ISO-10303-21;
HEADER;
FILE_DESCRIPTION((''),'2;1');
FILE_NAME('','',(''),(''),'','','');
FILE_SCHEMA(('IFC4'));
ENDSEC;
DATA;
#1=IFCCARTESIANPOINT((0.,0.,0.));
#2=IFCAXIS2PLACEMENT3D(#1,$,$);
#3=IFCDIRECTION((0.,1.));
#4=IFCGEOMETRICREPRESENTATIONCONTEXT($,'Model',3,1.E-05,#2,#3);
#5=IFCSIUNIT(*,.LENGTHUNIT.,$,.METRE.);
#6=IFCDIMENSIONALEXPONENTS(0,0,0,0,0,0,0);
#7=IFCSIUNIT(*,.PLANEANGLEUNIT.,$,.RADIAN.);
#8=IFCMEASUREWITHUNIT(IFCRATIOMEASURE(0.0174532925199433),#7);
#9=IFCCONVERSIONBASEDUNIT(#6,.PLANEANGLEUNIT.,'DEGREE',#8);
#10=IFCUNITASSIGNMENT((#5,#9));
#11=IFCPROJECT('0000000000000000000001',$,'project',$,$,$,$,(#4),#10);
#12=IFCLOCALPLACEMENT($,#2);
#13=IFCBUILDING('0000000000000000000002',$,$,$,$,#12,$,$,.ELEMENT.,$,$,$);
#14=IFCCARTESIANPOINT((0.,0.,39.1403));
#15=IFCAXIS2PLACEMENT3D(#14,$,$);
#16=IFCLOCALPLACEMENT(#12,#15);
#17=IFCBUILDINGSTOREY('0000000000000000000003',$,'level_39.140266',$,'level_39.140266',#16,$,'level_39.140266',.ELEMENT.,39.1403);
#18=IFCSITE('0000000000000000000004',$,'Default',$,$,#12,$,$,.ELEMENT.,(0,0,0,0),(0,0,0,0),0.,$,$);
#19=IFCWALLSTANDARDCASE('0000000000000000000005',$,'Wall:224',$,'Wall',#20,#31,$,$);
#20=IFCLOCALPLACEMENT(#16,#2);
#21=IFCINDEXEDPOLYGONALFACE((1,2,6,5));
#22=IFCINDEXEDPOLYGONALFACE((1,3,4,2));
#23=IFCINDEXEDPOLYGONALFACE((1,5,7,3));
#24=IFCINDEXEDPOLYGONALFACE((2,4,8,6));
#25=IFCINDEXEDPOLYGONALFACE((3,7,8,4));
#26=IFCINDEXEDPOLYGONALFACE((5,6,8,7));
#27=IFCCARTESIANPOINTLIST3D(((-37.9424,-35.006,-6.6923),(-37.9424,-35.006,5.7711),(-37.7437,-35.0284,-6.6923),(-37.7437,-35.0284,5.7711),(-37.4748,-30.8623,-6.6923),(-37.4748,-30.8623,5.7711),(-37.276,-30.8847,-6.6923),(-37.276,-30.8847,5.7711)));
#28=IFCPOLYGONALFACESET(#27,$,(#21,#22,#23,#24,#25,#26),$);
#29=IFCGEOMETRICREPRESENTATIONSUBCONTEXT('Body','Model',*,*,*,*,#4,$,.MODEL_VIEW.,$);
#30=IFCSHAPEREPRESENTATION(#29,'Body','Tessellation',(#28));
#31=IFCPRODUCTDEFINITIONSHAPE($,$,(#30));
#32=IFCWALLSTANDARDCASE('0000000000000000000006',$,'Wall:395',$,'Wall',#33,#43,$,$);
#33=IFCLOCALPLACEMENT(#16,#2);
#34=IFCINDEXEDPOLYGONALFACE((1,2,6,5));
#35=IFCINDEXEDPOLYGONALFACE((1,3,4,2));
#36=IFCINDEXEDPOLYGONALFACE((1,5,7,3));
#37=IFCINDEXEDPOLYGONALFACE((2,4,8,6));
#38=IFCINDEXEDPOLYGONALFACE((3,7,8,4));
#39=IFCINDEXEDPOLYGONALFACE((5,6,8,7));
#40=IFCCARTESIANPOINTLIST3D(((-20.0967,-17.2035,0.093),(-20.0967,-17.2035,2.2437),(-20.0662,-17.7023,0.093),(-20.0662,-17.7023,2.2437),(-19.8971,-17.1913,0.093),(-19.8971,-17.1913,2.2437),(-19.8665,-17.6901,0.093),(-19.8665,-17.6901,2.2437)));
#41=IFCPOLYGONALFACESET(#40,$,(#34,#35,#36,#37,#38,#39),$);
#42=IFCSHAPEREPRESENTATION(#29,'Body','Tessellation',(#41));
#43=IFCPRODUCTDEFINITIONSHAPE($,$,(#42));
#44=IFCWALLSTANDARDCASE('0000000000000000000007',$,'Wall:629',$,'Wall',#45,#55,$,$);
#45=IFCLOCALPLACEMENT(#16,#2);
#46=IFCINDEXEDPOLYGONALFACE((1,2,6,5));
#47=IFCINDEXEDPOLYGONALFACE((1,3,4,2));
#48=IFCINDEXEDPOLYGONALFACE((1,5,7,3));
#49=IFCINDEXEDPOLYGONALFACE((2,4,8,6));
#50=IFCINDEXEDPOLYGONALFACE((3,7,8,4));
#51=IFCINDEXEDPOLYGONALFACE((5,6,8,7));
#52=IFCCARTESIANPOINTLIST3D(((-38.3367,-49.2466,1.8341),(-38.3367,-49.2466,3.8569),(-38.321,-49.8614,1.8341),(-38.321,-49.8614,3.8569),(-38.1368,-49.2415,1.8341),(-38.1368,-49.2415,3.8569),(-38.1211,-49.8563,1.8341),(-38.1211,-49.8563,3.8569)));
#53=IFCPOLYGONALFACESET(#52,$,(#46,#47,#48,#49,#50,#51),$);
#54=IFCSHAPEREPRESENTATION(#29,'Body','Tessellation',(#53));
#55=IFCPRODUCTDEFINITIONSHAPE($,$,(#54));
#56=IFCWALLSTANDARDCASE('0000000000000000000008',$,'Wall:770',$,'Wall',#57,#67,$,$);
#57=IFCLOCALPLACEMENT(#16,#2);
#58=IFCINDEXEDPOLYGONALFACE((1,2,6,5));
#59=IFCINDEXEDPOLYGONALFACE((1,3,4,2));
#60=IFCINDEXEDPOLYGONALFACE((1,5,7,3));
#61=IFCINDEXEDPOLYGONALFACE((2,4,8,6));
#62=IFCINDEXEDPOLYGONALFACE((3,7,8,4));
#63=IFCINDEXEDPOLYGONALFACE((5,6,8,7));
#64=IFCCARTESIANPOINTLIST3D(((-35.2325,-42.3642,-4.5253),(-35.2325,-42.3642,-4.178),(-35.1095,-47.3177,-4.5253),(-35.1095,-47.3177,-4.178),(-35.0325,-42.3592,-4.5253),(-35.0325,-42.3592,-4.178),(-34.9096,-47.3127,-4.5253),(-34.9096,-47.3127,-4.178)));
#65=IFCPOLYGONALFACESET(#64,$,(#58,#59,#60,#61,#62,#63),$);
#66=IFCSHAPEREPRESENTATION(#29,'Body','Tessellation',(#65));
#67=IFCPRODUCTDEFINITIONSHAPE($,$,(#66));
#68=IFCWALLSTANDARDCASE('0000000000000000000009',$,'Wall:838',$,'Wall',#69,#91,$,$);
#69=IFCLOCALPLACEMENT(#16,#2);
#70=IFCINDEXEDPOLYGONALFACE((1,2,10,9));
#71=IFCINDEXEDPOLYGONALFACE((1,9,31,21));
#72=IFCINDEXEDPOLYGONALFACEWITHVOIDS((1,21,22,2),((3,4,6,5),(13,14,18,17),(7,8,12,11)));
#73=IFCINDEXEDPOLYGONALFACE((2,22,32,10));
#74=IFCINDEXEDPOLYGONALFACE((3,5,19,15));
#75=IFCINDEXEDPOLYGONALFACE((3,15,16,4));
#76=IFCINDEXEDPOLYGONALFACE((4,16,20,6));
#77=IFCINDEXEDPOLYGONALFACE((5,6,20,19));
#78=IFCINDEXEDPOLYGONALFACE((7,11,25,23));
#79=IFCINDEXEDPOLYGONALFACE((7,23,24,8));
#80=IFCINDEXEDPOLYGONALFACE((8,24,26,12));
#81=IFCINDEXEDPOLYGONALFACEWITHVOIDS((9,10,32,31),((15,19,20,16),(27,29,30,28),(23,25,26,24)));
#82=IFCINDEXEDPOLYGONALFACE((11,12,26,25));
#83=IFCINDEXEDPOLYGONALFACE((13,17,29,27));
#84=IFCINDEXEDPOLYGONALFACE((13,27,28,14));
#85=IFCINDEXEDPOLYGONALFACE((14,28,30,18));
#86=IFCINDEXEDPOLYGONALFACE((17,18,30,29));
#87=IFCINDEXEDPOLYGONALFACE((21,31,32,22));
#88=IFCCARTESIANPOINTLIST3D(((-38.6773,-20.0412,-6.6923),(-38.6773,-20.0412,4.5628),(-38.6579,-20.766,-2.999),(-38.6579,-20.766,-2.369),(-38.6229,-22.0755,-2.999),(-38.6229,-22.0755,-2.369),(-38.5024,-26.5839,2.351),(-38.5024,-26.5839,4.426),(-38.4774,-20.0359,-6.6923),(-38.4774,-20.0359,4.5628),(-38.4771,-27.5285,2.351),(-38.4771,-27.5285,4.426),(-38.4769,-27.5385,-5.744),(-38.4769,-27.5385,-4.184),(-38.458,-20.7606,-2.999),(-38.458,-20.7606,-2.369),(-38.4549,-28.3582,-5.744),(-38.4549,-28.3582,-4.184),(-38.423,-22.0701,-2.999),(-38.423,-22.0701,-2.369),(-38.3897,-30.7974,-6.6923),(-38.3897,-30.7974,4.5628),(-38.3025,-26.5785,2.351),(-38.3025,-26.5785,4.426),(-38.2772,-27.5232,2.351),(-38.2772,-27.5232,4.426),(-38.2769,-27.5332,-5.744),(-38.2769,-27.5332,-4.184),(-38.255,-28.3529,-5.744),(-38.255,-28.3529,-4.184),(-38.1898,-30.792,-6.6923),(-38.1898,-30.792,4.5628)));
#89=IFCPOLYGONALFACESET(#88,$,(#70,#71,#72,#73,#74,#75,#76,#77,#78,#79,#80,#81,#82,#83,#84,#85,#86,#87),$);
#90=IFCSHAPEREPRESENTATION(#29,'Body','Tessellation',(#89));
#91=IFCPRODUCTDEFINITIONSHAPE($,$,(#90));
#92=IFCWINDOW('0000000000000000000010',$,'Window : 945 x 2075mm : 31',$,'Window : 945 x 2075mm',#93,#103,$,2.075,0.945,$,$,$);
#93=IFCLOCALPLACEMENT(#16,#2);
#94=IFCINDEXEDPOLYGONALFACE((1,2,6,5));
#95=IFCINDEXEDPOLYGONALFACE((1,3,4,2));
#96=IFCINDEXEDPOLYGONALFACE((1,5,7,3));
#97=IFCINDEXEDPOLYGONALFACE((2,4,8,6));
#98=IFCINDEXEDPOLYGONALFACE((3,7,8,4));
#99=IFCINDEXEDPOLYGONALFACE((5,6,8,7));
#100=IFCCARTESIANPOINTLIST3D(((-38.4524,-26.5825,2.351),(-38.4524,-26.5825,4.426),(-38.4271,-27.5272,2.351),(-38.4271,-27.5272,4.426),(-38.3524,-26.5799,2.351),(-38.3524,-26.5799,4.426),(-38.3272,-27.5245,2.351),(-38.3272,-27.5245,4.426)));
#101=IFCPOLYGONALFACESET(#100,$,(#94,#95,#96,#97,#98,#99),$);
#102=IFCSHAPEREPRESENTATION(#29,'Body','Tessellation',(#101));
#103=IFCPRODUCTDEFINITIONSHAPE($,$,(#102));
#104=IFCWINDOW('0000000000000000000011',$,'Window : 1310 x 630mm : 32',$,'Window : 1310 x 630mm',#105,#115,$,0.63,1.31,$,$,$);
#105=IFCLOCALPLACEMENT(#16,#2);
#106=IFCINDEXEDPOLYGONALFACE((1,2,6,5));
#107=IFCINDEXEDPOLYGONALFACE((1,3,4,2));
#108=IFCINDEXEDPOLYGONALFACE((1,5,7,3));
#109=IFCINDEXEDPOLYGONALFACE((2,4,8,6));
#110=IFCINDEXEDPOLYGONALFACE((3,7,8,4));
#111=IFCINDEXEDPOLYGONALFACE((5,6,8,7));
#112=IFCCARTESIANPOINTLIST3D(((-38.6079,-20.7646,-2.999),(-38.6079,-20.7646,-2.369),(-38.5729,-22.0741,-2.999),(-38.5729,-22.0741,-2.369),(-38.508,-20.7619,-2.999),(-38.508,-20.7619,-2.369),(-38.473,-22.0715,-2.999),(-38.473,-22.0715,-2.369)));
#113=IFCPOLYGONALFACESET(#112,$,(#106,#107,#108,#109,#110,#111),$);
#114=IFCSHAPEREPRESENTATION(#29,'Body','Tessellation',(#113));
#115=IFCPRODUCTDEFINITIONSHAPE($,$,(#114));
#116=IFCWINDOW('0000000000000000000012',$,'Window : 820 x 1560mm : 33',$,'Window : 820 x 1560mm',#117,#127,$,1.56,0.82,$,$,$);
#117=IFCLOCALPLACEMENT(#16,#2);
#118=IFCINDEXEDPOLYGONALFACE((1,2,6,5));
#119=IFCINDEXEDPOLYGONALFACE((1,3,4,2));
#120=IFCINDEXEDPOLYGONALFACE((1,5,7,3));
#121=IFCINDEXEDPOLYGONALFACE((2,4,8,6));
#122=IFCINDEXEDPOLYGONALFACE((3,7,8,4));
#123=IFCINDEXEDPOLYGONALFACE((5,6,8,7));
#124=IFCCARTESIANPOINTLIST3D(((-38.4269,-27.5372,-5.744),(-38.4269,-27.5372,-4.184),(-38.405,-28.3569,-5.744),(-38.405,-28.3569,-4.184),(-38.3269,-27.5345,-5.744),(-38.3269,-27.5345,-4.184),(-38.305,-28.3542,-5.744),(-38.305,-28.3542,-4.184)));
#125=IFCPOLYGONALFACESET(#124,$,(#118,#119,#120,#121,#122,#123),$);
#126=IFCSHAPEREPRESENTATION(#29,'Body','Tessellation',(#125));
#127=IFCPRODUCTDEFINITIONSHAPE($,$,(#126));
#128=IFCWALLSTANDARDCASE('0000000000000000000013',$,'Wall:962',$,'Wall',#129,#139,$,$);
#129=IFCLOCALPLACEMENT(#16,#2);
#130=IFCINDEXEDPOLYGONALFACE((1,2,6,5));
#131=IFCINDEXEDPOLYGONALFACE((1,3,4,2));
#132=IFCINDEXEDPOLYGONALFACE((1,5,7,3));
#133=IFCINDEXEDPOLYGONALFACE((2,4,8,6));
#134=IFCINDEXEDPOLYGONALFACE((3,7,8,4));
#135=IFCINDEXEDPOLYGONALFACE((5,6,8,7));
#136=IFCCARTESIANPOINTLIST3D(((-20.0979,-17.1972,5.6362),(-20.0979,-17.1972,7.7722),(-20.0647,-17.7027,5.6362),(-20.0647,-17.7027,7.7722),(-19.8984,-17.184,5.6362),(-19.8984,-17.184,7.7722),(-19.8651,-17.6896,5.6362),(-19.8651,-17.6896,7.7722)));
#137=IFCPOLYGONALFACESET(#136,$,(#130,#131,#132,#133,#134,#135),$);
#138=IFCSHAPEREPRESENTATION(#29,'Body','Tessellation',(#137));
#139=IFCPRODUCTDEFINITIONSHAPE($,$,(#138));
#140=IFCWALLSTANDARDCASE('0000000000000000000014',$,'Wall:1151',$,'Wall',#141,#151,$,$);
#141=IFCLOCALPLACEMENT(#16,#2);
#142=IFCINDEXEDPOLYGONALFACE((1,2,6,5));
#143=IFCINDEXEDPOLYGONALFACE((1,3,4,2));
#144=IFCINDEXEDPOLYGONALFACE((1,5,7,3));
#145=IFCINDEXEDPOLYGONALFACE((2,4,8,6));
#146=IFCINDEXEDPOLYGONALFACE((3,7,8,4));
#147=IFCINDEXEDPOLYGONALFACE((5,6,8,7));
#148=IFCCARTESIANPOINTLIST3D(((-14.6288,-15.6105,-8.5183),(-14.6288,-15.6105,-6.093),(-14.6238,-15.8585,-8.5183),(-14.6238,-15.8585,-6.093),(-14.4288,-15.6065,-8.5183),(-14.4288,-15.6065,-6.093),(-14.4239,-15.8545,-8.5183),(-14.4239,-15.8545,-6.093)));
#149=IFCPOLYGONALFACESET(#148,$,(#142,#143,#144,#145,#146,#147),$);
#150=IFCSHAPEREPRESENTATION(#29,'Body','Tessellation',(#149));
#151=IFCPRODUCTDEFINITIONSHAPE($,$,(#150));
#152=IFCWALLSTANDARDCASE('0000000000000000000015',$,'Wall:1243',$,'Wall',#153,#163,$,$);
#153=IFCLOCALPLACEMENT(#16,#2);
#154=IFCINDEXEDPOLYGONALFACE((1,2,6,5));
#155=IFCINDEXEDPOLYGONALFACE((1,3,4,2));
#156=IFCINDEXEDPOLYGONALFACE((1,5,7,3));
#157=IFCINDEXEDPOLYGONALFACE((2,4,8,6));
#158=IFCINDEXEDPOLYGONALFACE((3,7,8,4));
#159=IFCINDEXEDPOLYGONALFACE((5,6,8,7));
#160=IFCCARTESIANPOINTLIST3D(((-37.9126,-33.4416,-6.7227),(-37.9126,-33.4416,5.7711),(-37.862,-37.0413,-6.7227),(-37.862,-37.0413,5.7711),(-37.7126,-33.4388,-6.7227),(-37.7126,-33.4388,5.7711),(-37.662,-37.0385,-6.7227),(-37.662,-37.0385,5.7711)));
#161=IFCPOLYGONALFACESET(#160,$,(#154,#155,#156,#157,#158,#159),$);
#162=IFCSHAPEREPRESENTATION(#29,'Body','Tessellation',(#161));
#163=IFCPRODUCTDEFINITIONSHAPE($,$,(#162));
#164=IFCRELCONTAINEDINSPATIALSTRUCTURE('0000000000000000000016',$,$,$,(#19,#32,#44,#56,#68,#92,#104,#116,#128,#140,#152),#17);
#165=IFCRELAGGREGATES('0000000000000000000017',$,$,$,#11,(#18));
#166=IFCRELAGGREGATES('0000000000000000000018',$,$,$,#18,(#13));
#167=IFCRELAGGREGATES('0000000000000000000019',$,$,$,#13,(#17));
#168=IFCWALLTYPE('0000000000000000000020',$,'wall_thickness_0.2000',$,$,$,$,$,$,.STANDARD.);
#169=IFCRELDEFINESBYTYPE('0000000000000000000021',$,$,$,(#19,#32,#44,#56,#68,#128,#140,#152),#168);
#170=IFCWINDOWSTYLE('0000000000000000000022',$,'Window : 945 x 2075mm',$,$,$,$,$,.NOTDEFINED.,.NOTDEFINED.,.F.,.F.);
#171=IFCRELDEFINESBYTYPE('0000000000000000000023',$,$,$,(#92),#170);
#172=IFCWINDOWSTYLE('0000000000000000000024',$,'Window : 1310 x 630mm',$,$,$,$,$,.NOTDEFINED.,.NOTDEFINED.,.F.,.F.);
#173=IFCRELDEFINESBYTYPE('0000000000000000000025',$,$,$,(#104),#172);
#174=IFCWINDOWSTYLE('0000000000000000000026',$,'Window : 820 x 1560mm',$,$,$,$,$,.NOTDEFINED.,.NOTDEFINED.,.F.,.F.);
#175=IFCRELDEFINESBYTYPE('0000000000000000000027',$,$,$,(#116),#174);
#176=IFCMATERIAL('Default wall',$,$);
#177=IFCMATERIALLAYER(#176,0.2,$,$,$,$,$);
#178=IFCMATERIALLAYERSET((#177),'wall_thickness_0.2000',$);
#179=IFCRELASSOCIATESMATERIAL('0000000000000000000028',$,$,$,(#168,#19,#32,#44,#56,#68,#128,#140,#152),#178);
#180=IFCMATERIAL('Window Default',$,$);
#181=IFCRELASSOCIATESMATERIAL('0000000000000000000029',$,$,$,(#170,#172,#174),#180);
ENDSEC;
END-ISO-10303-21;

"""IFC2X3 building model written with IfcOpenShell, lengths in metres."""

from ifc_helpers import new_model, entity, si_unit, converted_unit, direction, frame, frame_2d, origin, origin_2d_with_axis, place, context, subcontext, project, spatial, polyline, rectangle, outline, extrude, source, transform, mapped, material, layer, layer_set, layer_usage, type_object, type_shapes, element, fill, save


model = new_model("IFC2X3")

# Units and contexts
model_context = context("Model", 3, precision=1e-05, world=origin(), true_north=direction((0.0, 1.0)))
body_context = subcontext(model_context, "Body", "Model", "MODEL_VIEW")
ifc_project = project(units=[si_unit("LENGTHUNIT", "METRE"), converted_unit("PLANEANGLEUNIT", "DEGREE", entity("IfcRatioMeasure", 0.0174532925199433), si_unit("PLANEANGLEUNIT", "RADIAN"), dimensions=[0, 0, 0, 0, 0, 0, 0])], contexts=[model_context])

# Site, building, storey
placement_1 = place(None, origin())
site = spatial("IfcSite", under=ifc_project, at=placement_1, Name="Default", CompositionType="ELEMENT", RefLatitude=(0, 0, 0, 0), RefLongitude=(0, 0, 0, 0), RefElevation=0.0)
building = spatial("IfcBuilding", under=site, at=placement_1, CompositionType="ELEMENT")
storey_placement = place(placement_1, frame((0.0, 0.0, 39.1403)))
storey = spatial("IfcBuildingStorey", under=building, at=storey_placement, Name="level_39.140266", ObjectType="level_39.140266", LongName="level_39.140266", CompositionType="ELEMENT", Elevation=39.1403)

# Walls
ifc_material_1 = material(Name="Default wall")
ifc_layer = layer(ifc_material_1, 0.2)
ifc_layer_set = layer_set([ifc_layer], Name="wall_thickness_0.2000")
ifc_layer_usage = layer_usage(ifc_layer_set, "AXIS2", "POSITIVE", -0.1)
wall_type = type_object("IfcWallType", Name="wall_thickness_0.2000", PredefinedType="STANDARD", material=ifc_layer_set)
placement_2 = place(placement_1, frame((0.0, 0.0, 32.448)))
wall_1_placement = place(placement_2, frame((-37.3754, -30.8735, 0.0), z_axis=(0.0, 0.0, 1.0), x_axis=(-0.11214, -0.993692, 0.0)))
element("IfcWallStandardCase", 1, at=wall_1_placement, inside=storey, type_object=wall_type, material=ifc_layer_usage, Name="Wall:224", ObjectType="Wall", context=body_context, shape_type="SweptSolid", body=[
    extrude(outline(polyline([(4.17, -0.1), (4.17, 0.1), (0.0, 0.1), (0.0, -0.1), (4.17, -0.1)])), origin(), (0.0, 0.0, 1.0), 12.4634),
])
placement_3 = place(placement_1, frame((0.0, 0.0, 39.2333)))
wall_2_placement = place(placement_3, frame((-19.9969, -17.1974, 0.0), z_axis=(0.0, 0.0, 1.0), x_axis=(0.061094, -0.998132, 0.0)))
element("IfcWallStandardCase", 2, at=wall_2_placement, inside=storey, type_object=wall_type, material=ifc_layer_usage, Name="Wall:395", ObjectType="Wall", context=body_context, shape_type="SweptSolid", body=[
    extrude(outline(polyline([(0.4997, -0.1), (0.4997, 0.1), (0.0, 0.1), (0.0, -0.1), (0.4997, -0.1)])), origin(), (0.0, 0.0, 1.0), 2.1507),
])
placement_4 = place(placement_1, frame((0.0, 0.0, 40.9744)))
wall_3_placement = place(placement_4, frame((-38.2367, -49.244, 0.0), z_axis=(0.0, 0.0, 1.0), x_axis=(0.025524, -0.999674, 0.0)))
element("IfcWallStandardCase", 3, at=wall_3_placement, inside=storey, type_object=wall_type, material=ifc_layer_usage, Name="Wall:629", ObjectType="Wall", context=body_context, shape_type="SweptSolid", body=[
    extrude(outline(polyline([(0.615, -0.1), (0.615, 0.1), (0.0, 0.1), (0.0, -0.1), (0.615, -0.1)])), origin(), (0.0, 0.0, 1.0), 2.0228),
])
placement_5 = place(placement_1, frame((0.0, 0.0, 34.615)))
wall_4_placement = place(placement_5, frame((-35.1325, -42.3617, 0.0), z_axis=(0.0, 0.0, 1.0), x_axis=(0.024812, -0.999692, 0.0)))
element("IfcWallStandardCase", 4, at=wall_4_placement, inside=storey, type_object=wall_type, material=ifc_layer_usage, Name="Wall:770", ObjectType="Wall", context=body_context, shape_type="SweptSolid", body=[
    extrude(outline(polyline([(4.955, -0.1), (4.955, 0.1), (0.0, 0.1), (0.0, -0.1), (4.955, -0.1)])), origin(), (0.0, 0.0, 1.0), 0.3472),
])

# Wall, openings, windows
placement_6 = place(placement_1, frame((0.0, 0.0, 32.448)))
wall_5_placement = place(placement_6, frame((-38.2898, -30.7947, 0.0), z_axis=(0.0, 0.0, 1.0), x_axis=(-0.026726, 0.999643, 0.0)))
wall_5 = element("IfcWallStandardCase", 5, at=wall_5_placement, inside=storey, type_object=wall_type, material=ifc_layer_usage, Name="Wall:838", ObjectType="Wall", context=body_context, shape_type="SweptSolid", body=[
    extrude(outline(polyline([(10.76, -0.1), (10.76, 0.1), (0.0, 0.1), (0.0, -0.1), (10.76, -0.1)])), origin(), (0.0, 0.0, 1.0), 11.2551),
])
opening_1_placement = place(wall_5_placement, frame((3.27, -0.1, 9.0433)))
opening_1 = element("IfcOpeningElement", 6, at=opening_1_placement, cuts=wall_5, ObjectType="Opening", context=body_context, shape_type="SweptSolid", body=[
    extrude(rectangle(XDim=0.945, YDim=2.075, at=frame_2d((1.0375, 0.4725), x_axis=(0.0, 1.0))), frame((0.0, 0.0, 0.0), z_axis=(0.0, 1.0, 0.0), x_axis=(0.0, 0.0, 1.0)), (0.0, 0.0, 1.0), 0.2),
])
opening_2_placement = place(wall_5_placement, frame((8.725, -0.1, 3.6933)))
opening_2 = element("IfcOpeningElement", 7, at=opening_2_placement, cuts=wall_5, ObjectType="Opening", context=body_context, shape_type="SweptSolid", body=[
    extrude(rectangle(XDim=1.31, YDim=0.63, at=frame_2d((0.315, 0.655), x_axis=(0.0, 1.0))), frame((0.0, 0.0, 0.0), z_axis=(0.0, 1.0, 0.0), x_axis=(0.0, 0.0, 1.0)), (0.0, 0.0, 1.0), 0.2),
])
opening_3_placement = place(wall_5_placement, frame((2.44, -0.1, 0.9483)))
opening_3 = element("IfcOpeningElement", 8, at=opening_3_placement, cuts=wall_5, ObjectType="Opening", context=body_context, shape_type="SweptSolid", body=[
    extrude(rectangle(XDim=0.82, YDim=1.56, at=frame_2d((0.78, 0.41), x_axis=(0.0, 1.0))), frame((0.0, 0.0, 0.0), z_axis=(0.0, 1.0, 0.0), x_axis=(0.0, 0.0, 1.0)), (0.0, 0.0, 1.0), 0.2),
])
ifc_material_2 = material(Name="Window Default")
window_style_1 = type_object("IfcWindowStyle", Name="Window : 945 x 2075mm", ConstructionType="NOTDEFINED", OperationType="NOTDEFINED", ParameterTakesPrecedence=False, Sizeable=False, material=ifc_material_2)
shared_shape_1 = source(origin(), body_context, "Body", "SweptSolid", [
    extrude(rectangle(XDim=0.1, YDim=0.945, at=origin_2d_with_axis()), frame((0.4725, 0.1, 0.0), z_axis=(0.0, 0.0, 1.0), x_axis=(0.0, 1.0, 0.0)), (0.0, 0.0, 1.0), 2.075),
])
type_shapes(window_style_1, [shared_shape_1])
window_1_placement = place(opening_1_placement, origin())
window_1 = element("IfcWindow", 9, at=window_1_placement, inside=storey, type_object=window_style_1, Name="Window : 945 x 2075mm : 31", ObjectType="Window : 945 x 2075mm", OverallHeight=2.075, OverallWidth=0.945, context=body_context, shape_type="MappedRepresentation", body=[
    mapped(shared_shape_1, transform((0.0, 0.0, 0.0), scale=1.0)),
])
fill(opening_1, window_1)
window_style_2 = type_object("IfcWindowStyle", Name="Window : 1310 x 630mm", ConstructionType="NOTDEFINED", OperationType="NOTDEFINED", ParameterTakesPrecedence=False, Sizeable=False, material=ifc_material_2)
shared_shape_2 = source(origin(), body_context, "Body", "SweptSolid", [
    extrude(rectangle(XDim=0.1, YDim=1.31, at=origin_2d_with_axis()), frame((0.655, 0.1, 0.0), z_axis=(0.0, 0.0, 1.0), x_axis=(0.0, 1.0, 0.0)), (0.0, 0.0, 1.0), 0.63),
])
type_shapes(window_style_2, [shared_shape_2])
window_2_placement = place(opening_2_placement, origin())
window_2 = element("IfcWindow", 10, at=window_2_placement, inside=storey, type_object=window_style_2, Name="Window : 1310 x 630mm : 32", ObjectType="Window : 1310 x 630mm", OverallHeight=0.63, OverallWidth=1.31, context=body_context, shape_type="MappedRepresentation", body=[
    mapped(shared_shape_2, transform((0.0, 0.0, 0.0), scale=1.0)),
])
fill(opening_2, window_2)
window_style_3 = type_object("IfcWindowStyle", Name="Window : 820 x 1560mm", ConstructionType="NOTDEFINED", OperationType="NOTDEFINED", ParameterTakesPrecedence=False, Sizeable=False, material=ifc_material_2)
shared_shape_3 = source(origin(), body_context, "Body", "SweptSolid", [
    extrude(rectangle(XDim=0.1, YDim=0.82, at=origin_2d_with_axis()), frame((0.41, 0.1, 0.0), z_axis=(0.0, 0.0, 1.0), x_axis=(0.0, 1.0, 0.0)), (0.0, 0.0, 1.0), 1.56),
])
type_shapes(window_style_3, [shared_shape_3])
window_3_placement = place(opening_3_placement, origin())
window_3 = element("IfcWindow", 11, at=window_3_placement, inside=storey, type_object=window_style_3, Name="Window : 820 x 1560mm : 33", ObjectType="Window : 820 x 1560mm", OverallHeight=1.56, OverallWidth=0.82, context=body_context, shape_type="MappedRepresentation", body=[
    mapped(shared_shape_3, transform((0.0, 0.0, 0.0), scale=1.0)),
])
fill(opening_3, window_3)

# Walls
placement_7 = place(placement_1, frame((0.0, 0.0, 44.7765)))
wall_6_placement = place(placement_7, frame((-19.9981, -17.1906, 0.0), z_axis=(0.0, 0.0, 1.0), x_axis=(0.065623, -0.997845, 0.0)))
element("IfcWallStandardCase", 12, at=wall_6_placement, inside=storey, type_object=wall_type, material=ifc_layer_usage, Name="Wall:962", ObjectType="Wall", context=body_context, shape_type="SweptSolid", body=[
    extrude(outline(polyline([(0.5066, -0.1), (0.5066, 0.1), (0.0, 0.1), (0.0, -0.1), (0.5066, -0.1)])), origin(), (0.0, 0.0, 1.0), 2.136),
])
placement_8 = place(placement_1, frame((0.0, 0.0, 30.622)))
wall_7_placement = place(placement_8, frame((-14.5238, -15.8565, 0.0), z_axis=(0.0, 0.0, 1.0), x_axis=(-0.019984, 0.9998, 0.0)))
element("IfcWallStandardCase", 13, at=wall_7_placement, inside=storey, type_object=wall_type, material=ifc_layer_usage, Name="Wall:1151", ObjectType="Wall", context=body_context, shape_type="SweptSolid", body=[
    extrude(outline(polyline([(0.248, -0.1), (0.248, 0.1), (0.0, 0.1), (0.0, -0.1), (0.248, -0.1)])), origin(), (0.0, 0.0, 1.0), 2.4253),
])
placement_9 = place(placement_1, frame((0.0, 0.0, 32.4176)))
wall_8_placement = place(placement_9, frame((-37.8126, -33.4402, 0.0), z_axis=(0.0, 0.0, 1.0), x_axis=(0.01406, -0.999901, 0.0)))
element("IfcWallStandardCase", 14, at=wall_8_placement, inside=storey, type_object=wall_type, material=ifc_layer_usage, Name="Wall:1243", ObjectType="Wall", context=body_context, shape_type="SweptSolid", body=[
    extrude(outline(polyline([(3.6, -0.1), (3.6, 0.1), (0.0, 0.1), (0.0, -0.1), (3.6, -0.1)])), origin(), (0.0, 0.0, 1.0), 12.4938),
])

save(model, "model.ifc")
